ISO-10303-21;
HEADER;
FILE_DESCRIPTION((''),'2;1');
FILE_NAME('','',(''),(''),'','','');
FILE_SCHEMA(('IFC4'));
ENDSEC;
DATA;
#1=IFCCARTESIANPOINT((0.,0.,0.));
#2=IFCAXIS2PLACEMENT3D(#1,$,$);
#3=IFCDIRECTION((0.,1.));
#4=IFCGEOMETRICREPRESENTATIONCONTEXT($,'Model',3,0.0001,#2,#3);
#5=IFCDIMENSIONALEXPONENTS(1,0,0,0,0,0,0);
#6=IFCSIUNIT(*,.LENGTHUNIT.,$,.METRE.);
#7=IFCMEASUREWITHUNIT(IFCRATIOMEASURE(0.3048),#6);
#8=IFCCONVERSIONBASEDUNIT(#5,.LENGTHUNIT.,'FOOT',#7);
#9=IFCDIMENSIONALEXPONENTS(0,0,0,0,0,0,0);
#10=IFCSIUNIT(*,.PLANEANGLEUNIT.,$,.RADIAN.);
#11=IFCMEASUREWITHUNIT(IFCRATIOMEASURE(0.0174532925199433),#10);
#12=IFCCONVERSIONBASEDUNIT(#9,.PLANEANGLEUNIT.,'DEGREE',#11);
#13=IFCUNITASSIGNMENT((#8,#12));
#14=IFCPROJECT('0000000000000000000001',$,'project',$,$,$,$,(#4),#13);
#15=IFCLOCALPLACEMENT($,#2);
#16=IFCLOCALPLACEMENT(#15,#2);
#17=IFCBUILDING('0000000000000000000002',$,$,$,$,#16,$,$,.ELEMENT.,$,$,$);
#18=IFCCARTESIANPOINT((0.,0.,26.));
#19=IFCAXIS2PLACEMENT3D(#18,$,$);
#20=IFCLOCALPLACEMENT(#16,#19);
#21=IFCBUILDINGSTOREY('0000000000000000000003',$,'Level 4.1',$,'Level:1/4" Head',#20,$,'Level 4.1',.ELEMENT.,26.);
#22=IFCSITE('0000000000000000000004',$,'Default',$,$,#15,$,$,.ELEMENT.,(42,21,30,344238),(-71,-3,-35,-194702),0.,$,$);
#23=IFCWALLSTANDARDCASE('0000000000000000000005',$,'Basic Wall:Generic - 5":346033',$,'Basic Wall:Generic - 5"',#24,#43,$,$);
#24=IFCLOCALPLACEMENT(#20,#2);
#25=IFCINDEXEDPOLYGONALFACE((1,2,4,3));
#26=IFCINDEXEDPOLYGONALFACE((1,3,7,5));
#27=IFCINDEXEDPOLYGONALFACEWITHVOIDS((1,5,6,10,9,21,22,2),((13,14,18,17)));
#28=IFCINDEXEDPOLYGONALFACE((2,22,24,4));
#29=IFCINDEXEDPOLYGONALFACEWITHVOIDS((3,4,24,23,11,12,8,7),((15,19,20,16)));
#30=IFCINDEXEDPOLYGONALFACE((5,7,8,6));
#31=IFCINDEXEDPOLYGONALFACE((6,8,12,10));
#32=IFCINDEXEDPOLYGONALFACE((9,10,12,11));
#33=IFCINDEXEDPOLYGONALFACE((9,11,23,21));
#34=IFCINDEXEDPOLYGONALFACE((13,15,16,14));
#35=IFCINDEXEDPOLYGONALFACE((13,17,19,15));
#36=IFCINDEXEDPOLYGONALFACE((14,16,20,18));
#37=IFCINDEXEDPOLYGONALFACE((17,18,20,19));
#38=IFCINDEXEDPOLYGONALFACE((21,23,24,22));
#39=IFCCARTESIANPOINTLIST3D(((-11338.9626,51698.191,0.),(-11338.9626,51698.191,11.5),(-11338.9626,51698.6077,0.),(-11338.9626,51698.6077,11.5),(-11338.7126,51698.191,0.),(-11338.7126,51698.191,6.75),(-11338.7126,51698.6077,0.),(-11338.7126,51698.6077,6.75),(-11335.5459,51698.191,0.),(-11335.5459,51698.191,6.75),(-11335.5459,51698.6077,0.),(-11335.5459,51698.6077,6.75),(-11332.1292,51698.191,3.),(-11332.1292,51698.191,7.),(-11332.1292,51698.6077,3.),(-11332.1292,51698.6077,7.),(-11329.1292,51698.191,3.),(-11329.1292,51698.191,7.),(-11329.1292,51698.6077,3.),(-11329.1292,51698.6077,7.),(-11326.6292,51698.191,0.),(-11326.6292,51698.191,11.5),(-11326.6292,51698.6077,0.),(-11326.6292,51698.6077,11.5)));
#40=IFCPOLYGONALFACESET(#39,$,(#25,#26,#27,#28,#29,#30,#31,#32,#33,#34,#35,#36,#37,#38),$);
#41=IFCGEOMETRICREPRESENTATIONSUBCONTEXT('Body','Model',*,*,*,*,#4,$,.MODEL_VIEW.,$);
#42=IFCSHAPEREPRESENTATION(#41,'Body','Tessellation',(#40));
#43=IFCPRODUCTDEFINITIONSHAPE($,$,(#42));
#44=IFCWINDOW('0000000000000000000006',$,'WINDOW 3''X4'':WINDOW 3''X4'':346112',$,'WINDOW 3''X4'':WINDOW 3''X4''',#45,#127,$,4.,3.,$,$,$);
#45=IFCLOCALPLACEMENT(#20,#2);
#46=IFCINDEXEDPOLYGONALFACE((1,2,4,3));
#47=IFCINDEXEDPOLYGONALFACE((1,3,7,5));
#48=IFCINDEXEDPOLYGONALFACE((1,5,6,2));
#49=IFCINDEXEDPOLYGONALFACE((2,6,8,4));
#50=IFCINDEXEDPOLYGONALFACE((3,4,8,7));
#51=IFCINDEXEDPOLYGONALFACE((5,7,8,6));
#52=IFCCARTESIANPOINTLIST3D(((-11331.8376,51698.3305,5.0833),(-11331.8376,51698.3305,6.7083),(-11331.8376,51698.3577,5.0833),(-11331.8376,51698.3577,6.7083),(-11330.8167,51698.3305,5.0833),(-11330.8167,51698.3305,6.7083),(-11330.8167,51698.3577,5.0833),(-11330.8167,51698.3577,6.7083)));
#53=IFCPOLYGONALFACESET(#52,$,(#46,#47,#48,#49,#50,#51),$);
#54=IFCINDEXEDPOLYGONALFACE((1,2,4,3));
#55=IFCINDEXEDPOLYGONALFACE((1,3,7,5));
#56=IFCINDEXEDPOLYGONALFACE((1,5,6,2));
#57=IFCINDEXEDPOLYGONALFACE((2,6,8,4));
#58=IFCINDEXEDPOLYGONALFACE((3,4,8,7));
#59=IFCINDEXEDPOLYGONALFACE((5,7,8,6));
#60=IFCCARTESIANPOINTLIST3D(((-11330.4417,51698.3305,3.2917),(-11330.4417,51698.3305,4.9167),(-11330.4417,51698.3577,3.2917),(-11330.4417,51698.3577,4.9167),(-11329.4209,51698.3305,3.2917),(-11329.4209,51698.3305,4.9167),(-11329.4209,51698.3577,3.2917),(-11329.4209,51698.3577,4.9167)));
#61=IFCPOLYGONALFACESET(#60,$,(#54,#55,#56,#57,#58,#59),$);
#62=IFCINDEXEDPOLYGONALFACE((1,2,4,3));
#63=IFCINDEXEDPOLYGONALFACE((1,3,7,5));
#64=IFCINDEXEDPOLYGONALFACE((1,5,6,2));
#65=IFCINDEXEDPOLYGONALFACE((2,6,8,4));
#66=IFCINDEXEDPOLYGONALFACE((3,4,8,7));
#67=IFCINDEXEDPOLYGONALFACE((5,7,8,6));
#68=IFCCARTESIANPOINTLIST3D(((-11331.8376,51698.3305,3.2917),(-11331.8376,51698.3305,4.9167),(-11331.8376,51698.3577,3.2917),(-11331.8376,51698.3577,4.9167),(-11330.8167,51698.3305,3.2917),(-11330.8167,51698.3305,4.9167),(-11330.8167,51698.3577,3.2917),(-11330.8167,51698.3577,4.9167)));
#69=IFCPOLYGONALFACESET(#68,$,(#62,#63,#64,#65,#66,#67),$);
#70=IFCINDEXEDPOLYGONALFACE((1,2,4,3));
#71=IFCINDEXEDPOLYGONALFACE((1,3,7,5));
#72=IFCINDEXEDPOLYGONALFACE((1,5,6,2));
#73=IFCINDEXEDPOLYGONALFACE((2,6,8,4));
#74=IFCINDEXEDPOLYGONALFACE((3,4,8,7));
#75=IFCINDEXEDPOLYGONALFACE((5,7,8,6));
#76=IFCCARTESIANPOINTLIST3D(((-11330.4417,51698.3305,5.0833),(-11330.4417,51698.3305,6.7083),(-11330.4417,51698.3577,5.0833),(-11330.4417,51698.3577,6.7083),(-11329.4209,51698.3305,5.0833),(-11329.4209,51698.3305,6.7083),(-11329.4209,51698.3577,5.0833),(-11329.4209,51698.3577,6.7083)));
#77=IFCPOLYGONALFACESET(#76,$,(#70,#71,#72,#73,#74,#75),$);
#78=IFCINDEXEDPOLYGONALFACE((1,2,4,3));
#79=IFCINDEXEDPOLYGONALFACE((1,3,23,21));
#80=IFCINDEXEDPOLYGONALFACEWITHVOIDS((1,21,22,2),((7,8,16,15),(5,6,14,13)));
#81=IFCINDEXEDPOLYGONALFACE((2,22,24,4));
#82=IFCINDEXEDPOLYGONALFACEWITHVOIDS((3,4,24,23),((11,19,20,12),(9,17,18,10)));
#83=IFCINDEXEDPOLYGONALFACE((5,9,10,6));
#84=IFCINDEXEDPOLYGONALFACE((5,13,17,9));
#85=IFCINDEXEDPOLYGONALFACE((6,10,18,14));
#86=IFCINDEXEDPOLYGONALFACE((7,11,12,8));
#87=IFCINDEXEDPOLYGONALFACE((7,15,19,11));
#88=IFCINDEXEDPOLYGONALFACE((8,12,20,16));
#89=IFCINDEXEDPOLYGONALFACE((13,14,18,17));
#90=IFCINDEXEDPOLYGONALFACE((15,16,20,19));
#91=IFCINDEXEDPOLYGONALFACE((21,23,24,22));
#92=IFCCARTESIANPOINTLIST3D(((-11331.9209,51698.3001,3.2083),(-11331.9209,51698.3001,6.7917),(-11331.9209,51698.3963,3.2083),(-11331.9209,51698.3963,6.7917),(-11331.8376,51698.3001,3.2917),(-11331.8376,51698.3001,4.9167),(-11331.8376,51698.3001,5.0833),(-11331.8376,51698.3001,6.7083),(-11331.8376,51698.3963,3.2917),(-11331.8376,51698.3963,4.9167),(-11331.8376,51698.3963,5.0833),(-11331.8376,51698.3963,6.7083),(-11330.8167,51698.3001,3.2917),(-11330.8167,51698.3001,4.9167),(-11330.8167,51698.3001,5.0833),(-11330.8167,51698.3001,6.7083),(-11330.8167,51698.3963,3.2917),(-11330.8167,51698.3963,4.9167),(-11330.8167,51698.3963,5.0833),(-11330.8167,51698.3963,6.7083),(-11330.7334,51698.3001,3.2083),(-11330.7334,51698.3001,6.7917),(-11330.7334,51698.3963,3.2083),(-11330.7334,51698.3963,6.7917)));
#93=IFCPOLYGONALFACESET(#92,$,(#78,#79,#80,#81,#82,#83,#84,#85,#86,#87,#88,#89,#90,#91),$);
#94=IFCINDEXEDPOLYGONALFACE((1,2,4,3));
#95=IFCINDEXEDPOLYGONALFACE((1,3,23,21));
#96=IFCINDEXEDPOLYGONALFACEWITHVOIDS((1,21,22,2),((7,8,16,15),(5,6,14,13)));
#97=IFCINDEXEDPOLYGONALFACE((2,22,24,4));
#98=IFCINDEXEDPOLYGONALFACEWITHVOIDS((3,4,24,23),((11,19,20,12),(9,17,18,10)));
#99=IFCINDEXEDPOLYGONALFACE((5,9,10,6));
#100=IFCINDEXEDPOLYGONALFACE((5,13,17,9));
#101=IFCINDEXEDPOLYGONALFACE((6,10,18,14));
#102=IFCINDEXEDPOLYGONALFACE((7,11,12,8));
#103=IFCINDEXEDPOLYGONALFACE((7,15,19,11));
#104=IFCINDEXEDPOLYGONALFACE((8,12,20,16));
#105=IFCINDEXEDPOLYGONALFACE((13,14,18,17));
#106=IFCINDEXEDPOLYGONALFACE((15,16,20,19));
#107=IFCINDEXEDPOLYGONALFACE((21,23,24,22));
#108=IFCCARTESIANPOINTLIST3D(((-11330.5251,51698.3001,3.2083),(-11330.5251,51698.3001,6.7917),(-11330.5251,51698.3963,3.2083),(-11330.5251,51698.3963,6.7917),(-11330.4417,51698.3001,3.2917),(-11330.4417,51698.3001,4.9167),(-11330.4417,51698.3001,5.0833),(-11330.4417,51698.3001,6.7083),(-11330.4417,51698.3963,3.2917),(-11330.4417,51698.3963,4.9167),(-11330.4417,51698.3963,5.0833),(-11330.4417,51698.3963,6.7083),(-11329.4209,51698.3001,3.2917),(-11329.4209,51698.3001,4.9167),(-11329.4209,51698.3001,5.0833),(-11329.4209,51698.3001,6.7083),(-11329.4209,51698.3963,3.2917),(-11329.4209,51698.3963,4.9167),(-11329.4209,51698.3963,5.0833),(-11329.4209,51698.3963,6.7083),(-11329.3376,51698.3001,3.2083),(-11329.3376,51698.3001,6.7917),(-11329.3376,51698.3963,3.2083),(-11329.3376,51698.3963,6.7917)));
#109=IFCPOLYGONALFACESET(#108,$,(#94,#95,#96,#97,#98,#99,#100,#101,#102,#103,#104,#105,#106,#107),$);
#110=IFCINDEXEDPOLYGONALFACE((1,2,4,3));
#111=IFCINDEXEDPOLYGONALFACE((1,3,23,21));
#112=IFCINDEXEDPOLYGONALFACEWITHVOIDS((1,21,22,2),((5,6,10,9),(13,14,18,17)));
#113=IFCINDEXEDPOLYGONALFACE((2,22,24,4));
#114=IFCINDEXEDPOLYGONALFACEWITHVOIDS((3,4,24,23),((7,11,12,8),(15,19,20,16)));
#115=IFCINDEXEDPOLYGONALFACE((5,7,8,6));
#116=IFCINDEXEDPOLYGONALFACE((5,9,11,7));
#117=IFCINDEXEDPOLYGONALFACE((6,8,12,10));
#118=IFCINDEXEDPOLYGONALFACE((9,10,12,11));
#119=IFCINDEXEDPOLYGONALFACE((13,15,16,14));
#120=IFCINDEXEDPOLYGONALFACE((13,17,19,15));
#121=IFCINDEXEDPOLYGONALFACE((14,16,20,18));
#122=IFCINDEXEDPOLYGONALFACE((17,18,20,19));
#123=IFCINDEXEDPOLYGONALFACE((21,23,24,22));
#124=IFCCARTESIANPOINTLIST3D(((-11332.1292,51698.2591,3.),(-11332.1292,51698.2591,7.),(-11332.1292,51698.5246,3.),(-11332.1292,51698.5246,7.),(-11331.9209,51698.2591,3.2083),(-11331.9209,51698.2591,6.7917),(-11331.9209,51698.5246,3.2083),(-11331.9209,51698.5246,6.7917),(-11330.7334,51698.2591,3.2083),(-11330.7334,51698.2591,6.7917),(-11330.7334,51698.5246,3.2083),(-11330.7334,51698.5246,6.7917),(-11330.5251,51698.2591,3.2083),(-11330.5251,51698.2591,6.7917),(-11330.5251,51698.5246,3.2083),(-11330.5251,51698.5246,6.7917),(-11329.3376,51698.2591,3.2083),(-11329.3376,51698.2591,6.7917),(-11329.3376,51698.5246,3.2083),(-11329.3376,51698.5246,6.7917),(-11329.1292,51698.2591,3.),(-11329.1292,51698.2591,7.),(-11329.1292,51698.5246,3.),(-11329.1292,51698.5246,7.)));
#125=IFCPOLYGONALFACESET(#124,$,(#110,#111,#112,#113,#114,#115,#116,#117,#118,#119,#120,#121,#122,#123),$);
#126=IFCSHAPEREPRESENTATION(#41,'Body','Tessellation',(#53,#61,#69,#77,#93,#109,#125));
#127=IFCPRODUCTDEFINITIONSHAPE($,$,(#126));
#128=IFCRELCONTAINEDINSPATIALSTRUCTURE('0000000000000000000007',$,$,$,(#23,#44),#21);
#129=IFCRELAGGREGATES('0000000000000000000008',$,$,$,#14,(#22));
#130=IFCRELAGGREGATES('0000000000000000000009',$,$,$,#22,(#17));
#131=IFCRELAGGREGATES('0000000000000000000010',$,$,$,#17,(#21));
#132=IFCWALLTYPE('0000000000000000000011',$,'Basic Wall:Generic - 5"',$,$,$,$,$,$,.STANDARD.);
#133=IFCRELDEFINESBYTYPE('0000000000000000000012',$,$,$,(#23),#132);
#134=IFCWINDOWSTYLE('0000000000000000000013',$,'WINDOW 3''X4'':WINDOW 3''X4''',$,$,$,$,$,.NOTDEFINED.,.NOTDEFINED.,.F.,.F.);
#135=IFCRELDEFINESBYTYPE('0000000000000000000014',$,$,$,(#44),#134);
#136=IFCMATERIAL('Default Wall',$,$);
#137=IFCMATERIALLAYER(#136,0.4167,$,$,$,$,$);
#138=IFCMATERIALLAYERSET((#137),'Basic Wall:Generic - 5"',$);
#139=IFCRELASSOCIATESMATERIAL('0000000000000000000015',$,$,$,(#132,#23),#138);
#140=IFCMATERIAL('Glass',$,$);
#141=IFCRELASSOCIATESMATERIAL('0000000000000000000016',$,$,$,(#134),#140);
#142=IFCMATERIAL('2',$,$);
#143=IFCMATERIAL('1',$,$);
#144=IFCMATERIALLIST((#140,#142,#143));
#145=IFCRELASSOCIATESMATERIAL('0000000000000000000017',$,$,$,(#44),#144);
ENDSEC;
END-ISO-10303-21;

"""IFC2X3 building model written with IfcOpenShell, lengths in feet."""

from ifc_helpers import new_model, entity, si_unit, converted_unit, direction, frame, frame_2d, origin, origin_2d_with_axis, place, context, subcontext, project, spatial, polyline, rectangle, outline, extrude, source, transform, mapped, material, material_list, layer, layer_set, layer_usage, type_object, type_shapes, element, fill, save


model = new_model("IFC2X3")

# Units and contexts
model_context = context("Model", 3, precision=0.0001, world=origin(), true_north=direction((0.0, 1.0)))
body_context = subcontext(model_context, "Body", "Model", "MODEL_VIEW")
ifc_project = project(units=[converted_unit("LENGTHUNIT", "FOOT", entity("IfcRatioMeasure", 0.3048), si_unit("LENGTHUNIT", "METRE"), dimensions=[1, 0, 0, 0, 0, 0, 0]), converted_unit("PLANEANGLEUNIT", "DEGREE", entity("IfcRatioMeasure", 0.0174532925199433), si_unit("PLANEANGLEUNIT", "RADIAN"), dimensions=[0, 0, 0, 0, 0, 0, 0])], contexts=[model_context])

# Site, building, storey
site_placement = place(None, origin())
site = spatial("IfcSite", under=ifc_project, at=site_placement, Name="Default", CompositionType="ELEMENT", RefLatitude=(42, 21, 30, 344238), RefLongitude=(-71, -3, -35, -194702), RefElevation=0.0)
building_placement = place(site_placement, origin())
building = spatial("IfcBuilding", under=site, at=building_placement, CompositionType="ELEMENT")
storey_placement = place(building_placement, frame((0.0, 0.0, 26.0)))
storey = spatial("IfcBuildingStorey", under=building, at=storey_placement, Name="Level 4.1", ObjectType="Level:1/4\" Head", LongName="Level 4.1", CompositionType="ELEMENT", Elevation=26.0)

# Shared definitions
ifc_material_1 = material(Name="Default Wall")

# Shared definitions
ifc_layer_1 = layer(ifc_material_1, 0.4167)
ifc_layer_set_1 = layer_set([ifc_layer_1], Name="Basic Wall:Generic - 5\"")
wall_type_1 = type_object("IfcWallType", Name="Basic Wall:Generic - 5\"", PredefinedType="STANDARD", material=ifc_layer_set_1)
ifc_material_2 = material(Name="Glass")
ifc_material_3 = material(Name="2")
ifc_material_4 = material(Name="1")

# Wall, openings, window
ifc_layer_usage_1 = layer_usage(ifc_layer_set_1, "AXIS2", "NEGATIVE", 0.2083)
wall_1_placement = place(storey_placement, frame((-11338.9626, 51698.3993, 0.0)))
wall_1 = element("IfcWallStandardCase", 1, at=wall_1_placement, inside=storey, type_object=wall_type_1, material=ifc_layer_usage_1, Name="Basic Wall:Generic - 5\":346033", ObjectType="Basic Wall:Generic - 5\"", context=body_context, shape_type="SweptSolid", body=[
    extrude(rectangle(XDim=12.3333, YDim=0.4167, at=frame_2d((6.1667, 0.0), x_axis=(-1.0, 0.0))), origin(), (0.0, 0.0, 1.0), 11.5),
])
opening_1_placement = place(wall_1_placement, frame((0.25, -0.2083, 0.0)))
element("IfcOpeningElement", 2, at=opening_1_placement, cuts=wall_1, ObjectType="Opening", context=body_context, shape_type="SweptSolid", body=[
    extrude(rectangle(XDim=6.75, YDim=3.1667, at=frame_2d((3.375, 1.5833), x_axis=(1.0, 0.0))), frame((0.0, 0.0, 0.0), z_axis=(0.0, 1.0, 0.0), x_axis=(0.0, 0.0, 1.0)), (0.0, 0.0, 1.0), 0.4167),
])
opening_2_placement = place(wall_1_placement, frame((9.8333, 0.2083, 3.0)))
opening_2 = element("IfcOpeningElement", 3, at=opening_2_placement, cuts=wall_1, ObjectType="Opening", context=body_context, shape_type="SweptSolid", body=[
    extrude(rectangle(XDim=4.0, YDim=3.0, at=frame_2d((2.0, 1.5), x_axis=(-1.0, 0.0))), frame((0.0, 0.0, 0.0), z_axis=(0.0, -1.0, 0.0), x_axis=(0.0, 0.0, 1.0)), (0.0, 0.0, 1.0), 0.4167),
])
ifc_material_list_1 = material_list([ifc_material_2, ifc_material_3, ifc_material_4])
window_style_1 = type_object("IfcWindowStyle", Name="WINDOW 3'X4':WINDOW 3'X4'", ConstructionType="NOTDEFINED", OperationType="NOTDEFINED", ParameterTakesPrecedence=False, Sizeable=False, material=ifc_material_2)
shared_shape_1 = source(origin(), body_context, "Body", "SweptSolid", [
    extrude(rectangle(XDim=0.0272, YDim=1.0208, at=origin_2d_with_axis()), frame((2.1979, 0.2636, 2.0833), z_axis=(0.0, 0.0, 1.0), x_axis=(0.0, 1.0, 0.0)), (0.0, 0.0, 1.0), 1.625),
    extrude(rectangle(XDim=0.0272, YDim=1.0208, at=origin_2d_with_axis()), frame((0.8021, 0.2636, 0.2917), z_axis=(0.0, 0.0, 1.0), x_axis=(0.0, 1.0, 0.0)), (0.0, 0.0, 1.0), 1.625),
    extrude(rectangle(XDim=0.0272, YDim=1.0208, at=origin_2d_with_axis()), frame((2.1979, 0.2636, 0.2917), z_axis=(0.0, 0.0, 1.0), x_axis=(0.0, 1.0, 0.0)), (0.0, 0.0, 1.0), 1.625),
    extrude(rectangle(XDim=0.0272, YDim=1.0208, at=origin_2d_with_axis()), frame((0.8021, 0.2636, 2.0833), z_axis=(0.0, 0.0, 1.0), x_axis=(0.0, 1.0, 0.0)), (0.0, 0.0, 1.0), 1.625),
    extrude(outline(polyline([(-0.5938, -1.7917), (0.5938, -1.7917), (0.5938, 1.7917), (-0.5938, 1.7917), (-0.5938, -1.7917)]), holes=[polyline([(-0.5104, -0.0833), (0.5104, -0.0833), (0.5104, -1.7083), (-0.5104, -1.7083), (-0.5104, -0.0833)]), polyline([(-0.5104, 1.7083), (0.5104, 1.7083), (0.5104, 0.0833), (-0.5104, 0.0833), (-0.5104, 1.7083)])]), frame((2.1979, 0.2114, 2.0), z_axis=(0.0, 1.0, 0.0), x_axis=(-1.0, 0.0, 0.0)), (0.0, 0.0, 1.0), 0.0962),
    extrude(outline(polyline([(-1.7917, -0.5937), (1.7917, -0.5937), (1.7917, 0.5937), (-1.7917, 0.5937), (-1.7917, -0.5937)]), holes=[polyline([(0.0833, -0.5104), (0.0833, 0.5104), (1.7083, 0.5104), (1.7083, -0.5104), (0.0833, -0.5104)]), polyline([(-1.7083, -0.5104), (-1.7083, 0.5104), (-0.0833, 0.5104), (-0.0833, -0.5104), (-1.7083, -0.5104)])]), frame((0.8021, 0.2114, 2.0), z_axis=(0.0, 1.0, 0.0), x_axis=(0.0, 0.0, -1.0)), (0.0, 0.0, 1.0), 0.0962),
    extrude(outline(polyline([(-1.5, -2.0), (1.5, -2.0), (1.5, 2.0), (-1.5, 2.0), (-1.5, -2.0)]), holes=[polyline([(-0.1042, 1.7917), (-0.1042, -1.7917), (-1.2917, -1.7917), (-1.2917, 1.7917), (-0.1042, 1.7917)]), polyline([(0.1042, -1.7917), (0.1042, 1.7917), (1.2917, 1.7917), (1.2917, -1.7917), (0.1042, -1.7917)])]), frame((1.5, 0.0831, 2.0), z_axis=(0.0, 1.0, 0.0), x_axis=(1.0, 0.0, 0.0)), (0.0, 0.0, 1.0), 0.2655),
])
type_shapes(window_style_1, [shared_shape_1])
window_1_placement = place(opening_2_placement, frame((0.0, 0.0, 0.0), z_axis=(0.0, 0.0, 1.0), x_axis=(-1.0, 0.0, 0.0)))
window_1 = element("IfcWindow", 4, at=window_1_placement, inside=storey, type_object=window_style_1, material=ifc_material_list_1, Name="WINDOW 3'X4':WINDOW 3'X4':346112", ObjectType="WINDOW 3'X4':WINDOW 3'X4'", OverallHeight=4.0, OverallWidth=3.0, context=body_context, shape_type="MappedRepresentation", body=[
    mapped(shared_shape_1, transform((0.0, 0.0, 0.0), scale=1.0)),
])
fill(opening_2, window_1)

save(model, "model.ifc")
